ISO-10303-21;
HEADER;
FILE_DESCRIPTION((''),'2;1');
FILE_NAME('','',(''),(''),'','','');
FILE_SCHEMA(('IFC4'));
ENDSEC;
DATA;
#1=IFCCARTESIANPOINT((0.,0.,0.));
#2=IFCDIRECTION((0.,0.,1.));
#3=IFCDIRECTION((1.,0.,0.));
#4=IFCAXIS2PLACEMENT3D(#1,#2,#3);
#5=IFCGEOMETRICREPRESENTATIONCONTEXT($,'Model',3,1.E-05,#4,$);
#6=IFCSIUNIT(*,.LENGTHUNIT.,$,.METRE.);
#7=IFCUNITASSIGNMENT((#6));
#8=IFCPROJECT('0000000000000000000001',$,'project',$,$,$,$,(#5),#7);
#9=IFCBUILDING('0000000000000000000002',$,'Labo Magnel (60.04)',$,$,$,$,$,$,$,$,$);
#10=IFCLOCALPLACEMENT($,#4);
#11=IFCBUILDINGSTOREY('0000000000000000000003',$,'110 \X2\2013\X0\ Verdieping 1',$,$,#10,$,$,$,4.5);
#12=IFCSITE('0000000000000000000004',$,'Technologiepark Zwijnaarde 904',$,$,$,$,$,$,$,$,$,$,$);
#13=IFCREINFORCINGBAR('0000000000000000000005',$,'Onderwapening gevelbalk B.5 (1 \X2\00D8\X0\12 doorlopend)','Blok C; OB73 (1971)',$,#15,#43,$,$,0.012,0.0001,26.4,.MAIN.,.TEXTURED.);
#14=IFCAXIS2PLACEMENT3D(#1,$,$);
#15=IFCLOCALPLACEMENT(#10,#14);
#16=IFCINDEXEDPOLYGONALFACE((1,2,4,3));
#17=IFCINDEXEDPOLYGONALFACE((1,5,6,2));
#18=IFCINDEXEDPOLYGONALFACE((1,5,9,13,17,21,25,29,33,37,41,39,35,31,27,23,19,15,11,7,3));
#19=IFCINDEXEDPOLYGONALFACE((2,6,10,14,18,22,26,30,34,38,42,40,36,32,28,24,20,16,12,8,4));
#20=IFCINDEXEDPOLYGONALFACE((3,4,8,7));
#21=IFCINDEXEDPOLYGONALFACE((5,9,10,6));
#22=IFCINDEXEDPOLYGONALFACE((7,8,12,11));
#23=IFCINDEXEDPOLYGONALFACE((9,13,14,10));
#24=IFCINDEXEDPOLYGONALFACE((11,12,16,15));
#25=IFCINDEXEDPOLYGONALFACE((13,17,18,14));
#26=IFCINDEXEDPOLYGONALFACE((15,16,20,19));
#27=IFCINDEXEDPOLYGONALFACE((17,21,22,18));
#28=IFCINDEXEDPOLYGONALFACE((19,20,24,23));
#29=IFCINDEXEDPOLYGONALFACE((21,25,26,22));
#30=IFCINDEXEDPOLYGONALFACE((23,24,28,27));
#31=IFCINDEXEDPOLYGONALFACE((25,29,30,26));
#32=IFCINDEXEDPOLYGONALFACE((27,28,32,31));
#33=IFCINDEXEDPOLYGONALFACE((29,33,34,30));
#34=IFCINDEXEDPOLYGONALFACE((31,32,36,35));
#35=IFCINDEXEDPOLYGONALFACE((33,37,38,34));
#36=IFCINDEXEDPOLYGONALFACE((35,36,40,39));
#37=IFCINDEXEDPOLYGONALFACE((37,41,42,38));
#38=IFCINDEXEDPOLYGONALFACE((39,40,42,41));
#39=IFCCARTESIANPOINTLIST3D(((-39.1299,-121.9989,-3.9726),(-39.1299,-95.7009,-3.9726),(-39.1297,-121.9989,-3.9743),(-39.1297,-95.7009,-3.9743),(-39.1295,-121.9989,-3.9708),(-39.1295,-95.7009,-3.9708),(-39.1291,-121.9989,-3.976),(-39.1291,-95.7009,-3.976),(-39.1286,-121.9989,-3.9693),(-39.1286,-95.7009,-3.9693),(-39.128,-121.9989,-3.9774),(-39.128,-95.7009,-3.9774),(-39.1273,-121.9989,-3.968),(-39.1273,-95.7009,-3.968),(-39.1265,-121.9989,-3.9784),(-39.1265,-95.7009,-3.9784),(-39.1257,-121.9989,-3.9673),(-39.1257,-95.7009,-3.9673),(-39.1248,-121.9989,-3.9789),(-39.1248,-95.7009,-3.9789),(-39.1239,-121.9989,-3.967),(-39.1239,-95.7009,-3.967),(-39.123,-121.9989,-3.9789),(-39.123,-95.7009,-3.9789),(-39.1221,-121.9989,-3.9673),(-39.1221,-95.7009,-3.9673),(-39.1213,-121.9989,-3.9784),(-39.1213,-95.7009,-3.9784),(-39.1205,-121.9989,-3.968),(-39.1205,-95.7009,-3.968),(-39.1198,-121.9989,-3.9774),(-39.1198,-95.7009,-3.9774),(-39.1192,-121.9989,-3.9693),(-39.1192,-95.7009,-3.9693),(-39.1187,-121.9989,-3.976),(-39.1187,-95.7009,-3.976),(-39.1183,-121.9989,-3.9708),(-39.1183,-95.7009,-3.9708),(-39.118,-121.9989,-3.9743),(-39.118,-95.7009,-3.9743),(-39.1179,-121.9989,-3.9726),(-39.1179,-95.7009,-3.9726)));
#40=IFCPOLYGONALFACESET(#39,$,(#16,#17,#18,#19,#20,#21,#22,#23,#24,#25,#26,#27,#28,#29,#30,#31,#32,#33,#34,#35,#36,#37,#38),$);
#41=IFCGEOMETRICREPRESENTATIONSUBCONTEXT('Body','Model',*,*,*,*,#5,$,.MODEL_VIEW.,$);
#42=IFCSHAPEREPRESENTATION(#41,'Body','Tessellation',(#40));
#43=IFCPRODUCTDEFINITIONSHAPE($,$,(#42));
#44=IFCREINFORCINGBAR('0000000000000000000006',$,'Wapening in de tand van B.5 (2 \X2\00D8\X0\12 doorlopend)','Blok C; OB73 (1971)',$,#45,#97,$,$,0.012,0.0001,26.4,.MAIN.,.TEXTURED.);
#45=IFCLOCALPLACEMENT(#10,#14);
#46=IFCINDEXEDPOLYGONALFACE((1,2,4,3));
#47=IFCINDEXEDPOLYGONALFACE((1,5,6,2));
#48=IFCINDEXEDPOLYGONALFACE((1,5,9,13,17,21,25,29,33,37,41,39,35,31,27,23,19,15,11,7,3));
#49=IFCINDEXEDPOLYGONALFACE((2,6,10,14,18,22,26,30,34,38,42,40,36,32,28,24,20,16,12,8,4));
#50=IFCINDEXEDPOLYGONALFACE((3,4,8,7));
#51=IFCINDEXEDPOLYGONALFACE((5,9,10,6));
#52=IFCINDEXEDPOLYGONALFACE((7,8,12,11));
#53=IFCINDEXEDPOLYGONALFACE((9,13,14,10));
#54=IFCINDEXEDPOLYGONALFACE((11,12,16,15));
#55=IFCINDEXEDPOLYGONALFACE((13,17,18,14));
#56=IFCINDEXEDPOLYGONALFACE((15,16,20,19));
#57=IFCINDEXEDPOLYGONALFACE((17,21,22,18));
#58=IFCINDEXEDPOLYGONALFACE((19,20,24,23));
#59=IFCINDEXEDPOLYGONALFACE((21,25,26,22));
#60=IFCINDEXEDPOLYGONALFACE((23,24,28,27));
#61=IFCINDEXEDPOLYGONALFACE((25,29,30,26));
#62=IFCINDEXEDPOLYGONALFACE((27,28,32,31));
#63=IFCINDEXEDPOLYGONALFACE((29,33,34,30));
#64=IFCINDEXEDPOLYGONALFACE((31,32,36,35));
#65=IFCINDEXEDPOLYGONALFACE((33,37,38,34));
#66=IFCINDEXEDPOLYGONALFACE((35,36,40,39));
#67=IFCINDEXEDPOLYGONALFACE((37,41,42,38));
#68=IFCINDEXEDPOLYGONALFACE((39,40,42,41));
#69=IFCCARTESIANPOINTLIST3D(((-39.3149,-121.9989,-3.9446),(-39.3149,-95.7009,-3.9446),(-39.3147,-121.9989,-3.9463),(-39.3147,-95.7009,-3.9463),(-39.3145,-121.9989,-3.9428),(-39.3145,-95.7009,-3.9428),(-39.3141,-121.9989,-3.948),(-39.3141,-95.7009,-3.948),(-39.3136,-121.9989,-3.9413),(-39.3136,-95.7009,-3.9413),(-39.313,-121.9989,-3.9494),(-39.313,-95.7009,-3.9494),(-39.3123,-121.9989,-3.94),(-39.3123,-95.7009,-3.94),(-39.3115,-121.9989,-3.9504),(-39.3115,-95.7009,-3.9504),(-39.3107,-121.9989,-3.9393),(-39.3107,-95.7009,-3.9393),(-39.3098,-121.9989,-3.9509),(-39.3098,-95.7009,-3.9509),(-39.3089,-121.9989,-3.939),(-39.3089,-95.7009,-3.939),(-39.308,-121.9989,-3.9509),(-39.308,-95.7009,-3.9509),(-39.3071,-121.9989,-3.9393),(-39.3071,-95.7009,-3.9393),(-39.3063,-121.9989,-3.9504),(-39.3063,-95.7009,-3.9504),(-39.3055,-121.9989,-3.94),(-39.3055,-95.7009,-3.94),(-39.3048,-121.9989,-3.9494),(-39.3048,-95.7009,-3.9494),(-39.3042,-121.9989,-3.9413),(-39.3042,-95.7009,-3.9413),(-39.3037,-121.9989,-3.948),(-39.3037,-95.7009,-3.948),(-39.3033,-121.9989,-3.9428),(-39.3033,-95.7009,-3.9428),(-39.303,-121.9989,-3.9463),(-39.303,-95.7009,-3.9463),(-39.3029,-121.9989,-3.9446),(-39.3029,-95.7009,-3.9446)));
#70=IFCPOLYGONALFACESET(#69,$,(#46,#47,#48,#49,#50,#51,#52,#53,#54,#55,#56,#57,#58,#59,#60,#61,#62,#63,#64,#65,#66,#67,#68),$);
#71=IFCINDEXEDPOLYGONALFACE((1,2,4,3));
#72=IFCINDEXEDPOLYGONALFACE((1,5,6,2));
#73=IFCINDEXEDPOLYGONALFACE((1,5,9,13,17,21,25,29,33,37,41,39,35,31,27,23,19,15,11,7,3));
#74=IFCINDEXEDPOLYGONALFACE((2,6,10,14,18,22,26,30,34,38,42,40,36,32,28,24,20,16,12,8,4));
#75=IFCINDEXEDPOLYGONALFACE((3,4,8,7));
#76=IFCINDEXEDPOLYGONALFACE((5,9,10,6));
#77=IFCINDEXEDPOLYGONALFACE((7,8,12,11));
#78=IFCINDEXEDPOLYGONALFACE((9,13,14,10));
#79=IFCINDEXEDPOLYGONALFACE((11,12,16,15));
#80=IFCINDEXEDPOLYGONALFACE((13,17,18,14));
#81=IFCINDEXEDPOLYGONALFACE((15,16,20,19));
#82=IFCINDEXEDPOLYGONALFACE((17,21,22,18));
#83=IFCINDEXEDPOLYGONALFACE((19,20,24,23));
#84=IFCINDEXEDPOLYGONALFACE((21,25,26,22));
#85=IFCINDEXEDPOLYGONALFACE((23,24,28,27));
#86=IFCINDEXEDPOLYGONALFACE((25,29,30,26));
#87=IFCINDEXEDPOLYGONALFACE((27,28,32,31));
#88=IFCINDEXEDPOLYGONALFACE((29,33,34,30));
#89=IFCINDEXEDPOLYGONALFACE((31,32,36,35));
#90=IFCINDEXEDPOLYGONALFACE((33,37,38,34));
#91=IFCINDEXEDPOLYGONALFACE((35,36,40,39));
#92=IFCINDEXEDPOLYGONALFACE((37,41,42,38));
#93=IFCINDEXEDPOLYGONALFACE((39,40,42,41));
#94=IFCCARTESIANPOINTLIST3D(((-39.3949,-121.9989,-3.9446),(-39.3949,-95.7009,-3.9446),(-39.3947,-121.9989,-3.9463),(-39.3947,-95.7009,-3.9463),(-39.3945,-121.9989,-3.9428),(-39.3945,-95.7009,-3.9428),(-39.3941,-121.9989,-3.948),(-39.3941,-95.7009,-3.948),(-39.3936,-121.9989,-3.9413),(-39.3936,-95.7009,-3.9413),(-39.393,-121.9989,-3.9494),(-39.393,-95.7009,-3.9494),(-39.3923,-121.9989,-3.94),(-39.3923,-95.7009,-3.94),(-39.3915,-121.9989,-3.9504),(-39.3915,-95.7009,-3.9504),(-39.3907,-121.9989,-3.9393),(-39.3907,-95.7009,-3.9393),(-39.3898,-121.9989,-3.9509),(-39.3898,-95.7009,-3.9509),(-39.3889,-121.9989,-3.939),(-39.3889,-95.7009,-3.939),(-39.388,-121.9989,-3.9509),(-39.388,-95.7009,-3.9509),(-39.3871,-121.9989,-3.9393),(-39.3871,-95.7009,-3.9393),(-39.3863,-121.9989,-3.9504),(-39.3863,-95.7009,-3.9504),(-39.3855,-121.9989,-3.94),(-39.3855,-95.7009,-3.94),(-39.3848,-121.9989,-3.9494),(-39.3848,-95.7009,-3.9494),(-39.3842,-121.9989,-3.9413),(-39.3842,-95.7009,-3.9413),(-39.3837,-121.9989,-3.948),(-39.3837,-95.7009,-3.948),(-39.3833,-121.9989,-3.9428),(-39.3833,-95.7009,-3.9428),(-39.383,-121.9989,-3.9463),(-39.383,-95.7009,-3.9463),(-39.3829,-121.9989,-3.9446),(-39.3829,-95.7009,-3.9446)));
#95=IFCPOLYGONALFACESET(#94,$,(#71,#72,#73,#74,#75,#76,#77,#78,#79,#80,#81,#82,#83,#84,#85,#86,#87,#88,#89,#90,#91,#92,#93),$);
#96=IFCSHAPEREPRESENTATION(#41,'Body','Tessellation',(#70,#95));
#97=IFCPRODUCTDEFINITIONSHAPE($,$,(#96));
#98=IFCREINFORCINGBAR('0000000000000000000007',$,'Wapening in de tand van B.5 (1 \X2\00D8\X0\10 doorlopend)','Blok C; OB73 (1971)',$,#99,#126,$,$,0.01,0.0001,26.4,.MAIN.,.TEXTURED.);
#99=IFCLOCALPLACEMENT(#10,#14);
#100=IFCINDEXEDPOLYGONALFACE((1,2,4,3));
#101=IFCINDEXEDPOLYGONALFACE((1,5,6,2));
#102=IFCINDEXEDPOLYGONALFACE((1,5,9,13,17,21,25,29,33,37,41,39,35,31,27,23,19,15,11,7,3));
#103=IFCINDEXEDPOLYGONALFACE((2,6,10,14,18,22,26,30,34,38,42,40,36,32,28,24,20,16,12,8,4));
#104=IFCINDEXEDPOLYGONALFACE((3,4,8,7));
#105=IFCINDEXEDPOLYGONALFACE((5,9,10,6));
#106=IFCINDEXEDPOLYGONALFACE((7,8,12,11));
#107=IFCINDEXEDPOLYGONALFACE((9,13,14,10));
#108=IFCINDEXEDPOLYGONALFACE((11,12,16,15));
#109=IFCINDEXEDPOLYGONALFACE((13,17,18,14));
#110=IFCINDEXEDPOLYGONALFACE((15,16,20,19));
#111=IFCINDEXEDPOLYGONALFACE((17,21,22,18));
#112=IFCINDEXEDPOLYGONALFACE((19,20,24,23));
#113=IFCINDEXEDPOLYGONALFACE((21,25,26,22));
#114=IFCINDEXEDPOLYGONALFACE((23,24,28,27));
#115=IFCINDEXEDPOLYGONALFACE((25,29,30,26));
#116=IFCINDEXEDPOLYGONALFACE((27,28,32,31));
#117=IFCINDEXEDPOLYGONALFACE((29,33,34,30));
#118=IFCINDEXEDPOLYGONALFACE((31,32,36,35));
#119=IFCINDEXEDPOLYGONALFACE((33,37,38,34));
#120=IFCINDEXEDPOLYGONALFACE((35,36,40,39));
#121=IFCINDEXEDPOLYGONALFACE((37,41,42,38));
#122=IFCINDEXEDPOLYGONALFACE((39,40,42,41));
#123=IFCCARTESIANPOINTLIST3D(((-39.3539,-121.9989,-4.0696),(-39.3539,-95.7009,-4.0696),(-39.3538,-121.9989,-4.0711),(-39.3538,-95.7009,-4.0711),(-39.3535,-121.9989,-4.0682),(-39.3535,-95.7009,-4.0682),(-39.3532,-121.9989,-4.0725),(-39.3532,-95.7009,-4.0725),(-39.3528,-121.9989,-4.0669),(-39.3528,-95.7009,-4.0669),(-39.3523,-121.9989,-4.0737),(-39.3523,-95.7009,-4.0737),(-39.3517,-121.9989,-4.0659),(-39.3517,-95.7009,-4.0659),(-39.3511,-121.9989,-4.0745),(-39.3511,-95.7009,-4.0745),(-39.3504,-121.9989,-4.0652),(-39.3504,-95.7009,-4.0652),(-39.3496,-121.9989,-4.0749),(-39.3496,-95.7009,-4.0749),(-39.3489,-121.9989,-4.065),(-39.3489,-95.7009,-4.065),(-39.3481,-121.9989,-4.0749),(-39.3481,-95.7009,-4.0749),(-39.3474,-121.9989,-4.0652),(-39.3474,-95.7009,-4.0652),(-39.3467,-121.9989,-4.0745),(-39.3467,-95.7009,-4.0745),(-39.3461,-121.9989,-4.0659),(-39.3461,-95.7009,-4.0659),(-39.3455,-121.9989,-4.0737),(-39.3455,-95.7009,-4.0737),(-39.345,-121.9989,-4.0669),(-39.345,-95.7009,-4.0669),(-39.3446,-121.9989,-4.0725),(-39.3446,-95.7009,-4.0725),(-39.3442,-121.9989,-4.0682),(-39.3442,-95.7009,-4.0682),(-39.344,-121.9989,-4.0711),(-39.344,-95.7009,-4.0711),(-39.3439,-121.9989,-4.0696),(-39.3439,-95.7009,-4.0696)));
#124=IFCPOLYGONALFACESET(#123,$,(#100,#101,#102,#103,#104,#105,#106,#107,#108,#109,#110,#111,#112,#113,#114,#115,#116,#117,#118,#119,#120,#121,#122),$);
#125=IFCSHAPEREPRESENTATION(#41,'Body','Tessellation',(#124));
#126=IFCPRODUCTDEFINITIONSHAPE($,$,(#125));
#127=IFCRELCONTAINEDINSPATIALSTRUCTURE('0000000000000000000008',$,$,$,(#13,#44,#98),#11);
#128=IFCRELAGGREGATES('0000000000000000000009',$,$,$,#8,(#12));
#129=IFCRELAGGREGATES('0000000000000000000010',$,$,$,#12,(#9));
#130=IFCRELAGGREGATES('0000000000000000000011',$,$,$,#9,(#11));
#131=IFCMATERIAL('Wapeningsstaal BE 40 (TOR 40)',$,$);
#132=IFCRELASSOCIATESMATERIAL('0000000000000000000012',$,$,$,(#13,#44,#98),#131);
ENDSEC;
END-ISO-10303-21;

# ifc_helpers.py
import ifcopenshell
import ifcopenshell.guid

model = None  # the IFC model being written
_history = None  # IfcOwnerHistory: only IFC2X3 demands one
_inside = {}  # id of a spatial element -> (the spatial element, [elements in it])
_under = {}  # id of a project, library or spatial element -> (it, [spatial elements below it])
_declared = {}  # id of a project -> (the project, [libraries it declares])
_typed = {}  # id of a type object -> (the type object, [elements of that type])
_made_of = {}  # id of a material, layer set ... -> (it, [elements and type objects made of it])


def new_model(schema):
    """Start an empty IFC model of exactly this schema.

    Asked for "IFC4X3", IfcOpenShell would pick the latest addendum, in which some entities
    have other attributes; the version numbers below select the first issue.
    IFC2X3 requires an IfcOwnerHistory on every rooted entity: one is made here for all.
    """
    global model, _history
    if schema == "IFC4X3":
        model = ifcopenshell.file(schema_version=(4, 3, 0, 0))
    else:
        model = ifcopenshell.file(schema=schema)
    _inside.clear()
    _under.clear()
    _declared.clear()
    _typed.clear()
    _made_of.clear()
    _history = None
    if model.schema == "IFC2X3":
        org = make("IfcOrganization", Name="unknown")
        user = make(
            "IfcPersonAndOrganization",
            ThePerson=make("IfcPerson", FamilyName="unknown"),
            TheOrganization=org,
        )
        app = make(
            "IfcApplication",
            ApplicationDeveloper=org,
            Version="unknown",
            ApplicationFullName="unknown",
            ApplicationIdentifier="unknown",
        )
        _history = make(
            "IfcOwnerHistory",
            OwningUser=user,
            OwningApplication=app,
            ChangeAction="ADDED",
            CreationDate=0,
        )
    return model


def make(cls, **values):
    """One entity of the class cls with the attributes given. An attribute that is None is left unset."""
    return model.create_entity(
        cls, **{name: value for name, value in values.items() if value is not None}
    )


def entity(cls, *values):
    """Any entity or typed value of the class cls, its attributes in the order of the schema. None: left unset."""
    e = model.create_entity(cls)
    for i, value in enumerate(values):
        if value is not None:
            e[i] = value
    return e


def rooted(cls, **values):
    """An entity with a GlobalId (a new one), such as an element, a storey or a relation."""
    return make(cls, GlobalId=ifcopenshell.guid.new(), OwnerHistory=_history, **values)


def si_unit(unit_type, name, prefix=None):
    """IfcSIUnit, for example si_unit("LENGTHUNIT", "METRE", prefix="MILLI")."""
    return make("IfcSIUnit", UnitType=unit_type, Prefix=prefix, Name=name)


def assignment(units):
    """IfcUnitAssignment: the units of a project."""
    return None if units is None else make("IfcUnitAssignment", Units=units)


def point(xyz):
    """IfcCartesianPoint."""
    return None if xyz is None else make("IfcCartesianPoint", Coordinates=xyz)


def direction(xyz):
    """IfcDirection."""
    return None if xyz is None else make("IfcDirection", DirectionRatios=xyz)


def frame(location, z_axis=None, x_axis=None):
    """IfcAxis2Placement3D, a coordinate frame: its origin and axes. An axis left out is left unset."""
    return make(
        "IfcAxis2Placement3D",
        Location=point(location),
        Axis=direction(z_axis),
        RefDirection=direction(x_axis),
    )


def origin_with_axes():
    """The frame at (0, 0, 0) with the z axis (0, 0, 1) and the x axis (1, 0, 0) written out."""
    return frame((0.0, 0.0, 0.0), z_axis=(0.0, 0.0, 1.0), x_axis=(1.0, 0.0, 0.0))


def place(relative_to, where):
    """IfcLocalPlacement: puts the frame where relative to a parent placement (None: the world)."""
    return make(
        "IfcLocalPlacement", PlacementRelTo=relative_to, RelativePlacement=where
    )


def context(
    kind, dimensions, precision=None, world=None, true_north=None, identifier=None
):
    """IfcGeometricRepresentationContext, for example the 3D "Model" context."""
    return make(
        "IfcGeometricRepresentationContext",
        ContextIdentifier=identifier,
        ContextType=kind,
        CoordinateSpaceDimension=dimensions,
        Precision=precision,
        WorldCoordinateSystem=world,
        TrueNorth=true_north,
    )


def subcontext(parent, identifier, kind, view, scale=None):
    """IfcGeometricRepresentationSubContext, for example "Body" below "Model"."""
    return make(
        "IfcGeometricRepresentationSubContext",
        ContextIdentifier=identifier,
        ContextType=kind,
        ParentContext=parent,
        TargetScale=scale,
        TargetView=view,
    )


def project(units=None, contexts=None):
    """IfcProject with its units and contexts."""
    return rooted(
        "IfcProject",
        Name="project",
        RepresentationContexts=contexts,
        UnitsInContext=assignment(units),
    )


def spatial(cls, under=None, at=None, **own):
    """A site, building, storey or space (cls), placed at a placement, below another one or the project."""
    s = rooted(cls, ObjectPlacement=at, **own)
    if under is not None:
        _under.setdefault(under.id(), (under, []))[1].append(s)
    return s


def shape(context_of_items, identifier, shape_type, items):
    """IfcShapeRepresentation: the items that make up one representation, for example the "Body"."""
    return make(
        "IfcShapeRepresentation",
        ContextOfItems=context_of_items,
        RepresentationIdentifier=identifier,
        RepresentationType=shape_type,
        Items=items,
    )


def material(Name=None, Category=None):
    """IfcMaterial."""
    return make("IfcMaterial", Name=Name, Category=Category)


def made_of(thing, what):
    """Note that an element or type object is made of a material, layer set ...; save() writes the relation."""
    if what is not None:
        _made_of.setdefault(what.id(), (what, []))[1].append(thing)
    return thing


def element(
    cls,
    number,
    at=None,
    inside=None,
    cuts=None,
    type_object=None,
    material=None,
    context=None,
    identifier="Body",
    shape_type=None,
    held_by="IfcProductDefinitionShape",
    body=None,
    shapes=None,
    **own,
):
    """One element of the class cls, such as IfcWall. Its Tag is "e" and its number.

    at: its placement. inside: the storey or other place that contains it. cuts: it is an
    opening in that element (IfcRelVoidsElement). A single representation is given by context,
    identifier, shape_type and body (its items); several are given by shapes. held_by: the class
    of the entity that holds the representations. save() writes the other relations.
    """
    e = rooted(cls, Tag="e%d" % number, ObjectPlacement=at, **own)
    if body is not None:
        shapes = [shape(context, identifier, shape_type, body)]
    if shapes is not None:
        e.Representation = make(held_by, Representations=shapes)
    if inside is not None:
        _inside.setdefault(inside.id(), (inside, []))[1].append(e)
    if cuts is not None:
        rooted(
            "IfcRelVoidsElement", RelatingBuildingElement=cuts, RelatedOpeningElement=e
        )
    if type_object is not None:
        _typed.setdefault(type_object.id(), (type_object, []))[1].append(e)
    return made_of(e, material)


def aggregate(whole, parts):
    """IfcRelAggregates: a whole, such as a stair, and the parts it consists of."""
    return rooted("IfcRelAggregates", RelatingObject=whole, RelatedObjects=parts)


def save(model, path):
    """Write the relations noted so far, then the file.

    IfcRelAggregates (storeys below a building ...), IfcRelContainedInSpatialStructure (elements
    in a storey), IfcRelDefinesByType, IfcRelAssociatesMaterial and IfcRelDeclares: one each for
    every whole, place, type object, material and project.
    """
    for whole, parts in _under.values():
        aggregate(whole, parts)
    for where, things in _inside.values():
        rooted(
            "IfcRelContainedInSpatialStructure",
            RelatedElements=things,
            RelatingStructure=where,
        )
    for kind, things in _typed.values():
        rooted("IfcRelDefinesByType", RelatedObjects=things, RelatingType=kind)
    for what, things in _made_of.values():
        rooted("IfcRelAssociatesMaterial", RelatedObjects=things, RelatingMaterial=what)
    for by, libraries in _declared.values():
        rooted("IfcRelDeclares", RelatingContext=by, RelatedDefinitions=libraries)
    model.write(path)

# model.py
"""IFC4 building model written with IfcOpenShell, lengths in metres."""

from ifc_helpers import new_model, entity, si_unit, origin_with_axes, place, context, subcontext, project, spatial, material, element, save


model = new_model("IFC4")

# Units and contexts
model_context = context("Model", 3, precision=1e-05, world=origin_with_axes())
body_context = subcontext(model_context, "Body", "Model", "MODEL_VIEW")
ifc_project = project(units=[si_unit("LENGTHUNIT", "METRE")], contexts=[model_context])

# Site, building, storey
site = spatial("IfcSite", under=ifc_project, Name="Technologiepark Zwijnaarde 904")
building = spatial("IfcBuilding", under=site, Name="Labo Magnel (60.04)")
storey_placement = place(None, origin_with_axes())
storey = spatial("IfcBuildingStorey", under=building, at=storey_placement, Name="110 – Verdieping 1", Elevation=4.5)

# Reinforcing bars
ifc_material_1 = material(Name="Wapeningsstaal BE 40 (TOR 40)")
reinforcing_bar_1_placement = place(storey_placement, origin_with_axes())
element("IfcReinforcingBar", 1, at=reinforcing_bar_1_placement, inside=storey, material=ifc_material_1, Name="Onderwapening gevelbalk B.5 (1 Ø12 doorlopend)", Description="Blok C; OB73 (1971)", BarLength=26.4, BarSurface="TEXTURED", CrossSectionArea=0.0001, NominalDiameter=0.012, PredefinedType="MAIN", context=body_context, shape_type="AdvancedSweptSolid", body=[
    entity("IfcSweptDiskSolid", entity("IfcPolyline", [entity("IfcCartesianPoint", [39.1239, 95.7009, 3.973]), entity("IfcCartesianPoint", [39.1239, 121.9989, 3.973])]), 0.006),
])
reinforcing_bar_2_placement = place(storey_placement, origin_with_axes())
element("IfcReinforcingBar", 2, at=reinforcing_bar_2_placement, inside=storey, material=ifc_material_1, Name="Wapening in de tand van B.5 (2 Ø12 doorlopend)", Description="Blok C; OB73 (1971)", BarLength=26.4, BarSurface="TEXTURED", CrossSectionArea=0.0001, NominalDiameter=0.012, PredefinedType="MAIN", context=body_context, shape_type="AdvancedSweptSolid", body=[
    entity("IfcSweptDiskSolid", entity("IfcPolyline", [entity("IfcCartesianPoint", [39.3089, 95.7009, 3.945]), entity("IfcCartesianPoint", [39.3089, 121.9989, 3.945])]), 0.006),
    entity("IfcSweptDiskSolid", entity("IfcPolyline", [entity("IfcCartesianPoint", [39.3889, 95.7009, 3.945]), entity("IfcCartesianPoint", [39.3889, 121.9989, 3.945])]), 0.006),
])
reinforcing_bar_3_placement = place(storey_placement, origin_with_axes())
element("IfcReinforcingBar", 3, at=reinforcing_bar_3_placement, inside=storey, material=ifc_material_1, Name="Wapening in de tand van B.5 (1 Ø10 doorlopend)", Description="Blok C; OB73 (1971)", BarLength=26.4, BarSurface="TEXTURED", CrossSectionArea=0.0001, NominalDiameter=0.01, PredefinedType="MAIN", context=body_context, shape_type="AdvancedSweptSolid", body=[
    entity("IfcSweptDiskSolid", entity("IfcPolyline", [entity("IfcCartesianPoint", [39.3489, 95.7009, 4.07]), entity("IfcCartesianPoint", [39.3489, 121.9989, 4.07])]), 0.005),
])

save(model, "model.ifc")
